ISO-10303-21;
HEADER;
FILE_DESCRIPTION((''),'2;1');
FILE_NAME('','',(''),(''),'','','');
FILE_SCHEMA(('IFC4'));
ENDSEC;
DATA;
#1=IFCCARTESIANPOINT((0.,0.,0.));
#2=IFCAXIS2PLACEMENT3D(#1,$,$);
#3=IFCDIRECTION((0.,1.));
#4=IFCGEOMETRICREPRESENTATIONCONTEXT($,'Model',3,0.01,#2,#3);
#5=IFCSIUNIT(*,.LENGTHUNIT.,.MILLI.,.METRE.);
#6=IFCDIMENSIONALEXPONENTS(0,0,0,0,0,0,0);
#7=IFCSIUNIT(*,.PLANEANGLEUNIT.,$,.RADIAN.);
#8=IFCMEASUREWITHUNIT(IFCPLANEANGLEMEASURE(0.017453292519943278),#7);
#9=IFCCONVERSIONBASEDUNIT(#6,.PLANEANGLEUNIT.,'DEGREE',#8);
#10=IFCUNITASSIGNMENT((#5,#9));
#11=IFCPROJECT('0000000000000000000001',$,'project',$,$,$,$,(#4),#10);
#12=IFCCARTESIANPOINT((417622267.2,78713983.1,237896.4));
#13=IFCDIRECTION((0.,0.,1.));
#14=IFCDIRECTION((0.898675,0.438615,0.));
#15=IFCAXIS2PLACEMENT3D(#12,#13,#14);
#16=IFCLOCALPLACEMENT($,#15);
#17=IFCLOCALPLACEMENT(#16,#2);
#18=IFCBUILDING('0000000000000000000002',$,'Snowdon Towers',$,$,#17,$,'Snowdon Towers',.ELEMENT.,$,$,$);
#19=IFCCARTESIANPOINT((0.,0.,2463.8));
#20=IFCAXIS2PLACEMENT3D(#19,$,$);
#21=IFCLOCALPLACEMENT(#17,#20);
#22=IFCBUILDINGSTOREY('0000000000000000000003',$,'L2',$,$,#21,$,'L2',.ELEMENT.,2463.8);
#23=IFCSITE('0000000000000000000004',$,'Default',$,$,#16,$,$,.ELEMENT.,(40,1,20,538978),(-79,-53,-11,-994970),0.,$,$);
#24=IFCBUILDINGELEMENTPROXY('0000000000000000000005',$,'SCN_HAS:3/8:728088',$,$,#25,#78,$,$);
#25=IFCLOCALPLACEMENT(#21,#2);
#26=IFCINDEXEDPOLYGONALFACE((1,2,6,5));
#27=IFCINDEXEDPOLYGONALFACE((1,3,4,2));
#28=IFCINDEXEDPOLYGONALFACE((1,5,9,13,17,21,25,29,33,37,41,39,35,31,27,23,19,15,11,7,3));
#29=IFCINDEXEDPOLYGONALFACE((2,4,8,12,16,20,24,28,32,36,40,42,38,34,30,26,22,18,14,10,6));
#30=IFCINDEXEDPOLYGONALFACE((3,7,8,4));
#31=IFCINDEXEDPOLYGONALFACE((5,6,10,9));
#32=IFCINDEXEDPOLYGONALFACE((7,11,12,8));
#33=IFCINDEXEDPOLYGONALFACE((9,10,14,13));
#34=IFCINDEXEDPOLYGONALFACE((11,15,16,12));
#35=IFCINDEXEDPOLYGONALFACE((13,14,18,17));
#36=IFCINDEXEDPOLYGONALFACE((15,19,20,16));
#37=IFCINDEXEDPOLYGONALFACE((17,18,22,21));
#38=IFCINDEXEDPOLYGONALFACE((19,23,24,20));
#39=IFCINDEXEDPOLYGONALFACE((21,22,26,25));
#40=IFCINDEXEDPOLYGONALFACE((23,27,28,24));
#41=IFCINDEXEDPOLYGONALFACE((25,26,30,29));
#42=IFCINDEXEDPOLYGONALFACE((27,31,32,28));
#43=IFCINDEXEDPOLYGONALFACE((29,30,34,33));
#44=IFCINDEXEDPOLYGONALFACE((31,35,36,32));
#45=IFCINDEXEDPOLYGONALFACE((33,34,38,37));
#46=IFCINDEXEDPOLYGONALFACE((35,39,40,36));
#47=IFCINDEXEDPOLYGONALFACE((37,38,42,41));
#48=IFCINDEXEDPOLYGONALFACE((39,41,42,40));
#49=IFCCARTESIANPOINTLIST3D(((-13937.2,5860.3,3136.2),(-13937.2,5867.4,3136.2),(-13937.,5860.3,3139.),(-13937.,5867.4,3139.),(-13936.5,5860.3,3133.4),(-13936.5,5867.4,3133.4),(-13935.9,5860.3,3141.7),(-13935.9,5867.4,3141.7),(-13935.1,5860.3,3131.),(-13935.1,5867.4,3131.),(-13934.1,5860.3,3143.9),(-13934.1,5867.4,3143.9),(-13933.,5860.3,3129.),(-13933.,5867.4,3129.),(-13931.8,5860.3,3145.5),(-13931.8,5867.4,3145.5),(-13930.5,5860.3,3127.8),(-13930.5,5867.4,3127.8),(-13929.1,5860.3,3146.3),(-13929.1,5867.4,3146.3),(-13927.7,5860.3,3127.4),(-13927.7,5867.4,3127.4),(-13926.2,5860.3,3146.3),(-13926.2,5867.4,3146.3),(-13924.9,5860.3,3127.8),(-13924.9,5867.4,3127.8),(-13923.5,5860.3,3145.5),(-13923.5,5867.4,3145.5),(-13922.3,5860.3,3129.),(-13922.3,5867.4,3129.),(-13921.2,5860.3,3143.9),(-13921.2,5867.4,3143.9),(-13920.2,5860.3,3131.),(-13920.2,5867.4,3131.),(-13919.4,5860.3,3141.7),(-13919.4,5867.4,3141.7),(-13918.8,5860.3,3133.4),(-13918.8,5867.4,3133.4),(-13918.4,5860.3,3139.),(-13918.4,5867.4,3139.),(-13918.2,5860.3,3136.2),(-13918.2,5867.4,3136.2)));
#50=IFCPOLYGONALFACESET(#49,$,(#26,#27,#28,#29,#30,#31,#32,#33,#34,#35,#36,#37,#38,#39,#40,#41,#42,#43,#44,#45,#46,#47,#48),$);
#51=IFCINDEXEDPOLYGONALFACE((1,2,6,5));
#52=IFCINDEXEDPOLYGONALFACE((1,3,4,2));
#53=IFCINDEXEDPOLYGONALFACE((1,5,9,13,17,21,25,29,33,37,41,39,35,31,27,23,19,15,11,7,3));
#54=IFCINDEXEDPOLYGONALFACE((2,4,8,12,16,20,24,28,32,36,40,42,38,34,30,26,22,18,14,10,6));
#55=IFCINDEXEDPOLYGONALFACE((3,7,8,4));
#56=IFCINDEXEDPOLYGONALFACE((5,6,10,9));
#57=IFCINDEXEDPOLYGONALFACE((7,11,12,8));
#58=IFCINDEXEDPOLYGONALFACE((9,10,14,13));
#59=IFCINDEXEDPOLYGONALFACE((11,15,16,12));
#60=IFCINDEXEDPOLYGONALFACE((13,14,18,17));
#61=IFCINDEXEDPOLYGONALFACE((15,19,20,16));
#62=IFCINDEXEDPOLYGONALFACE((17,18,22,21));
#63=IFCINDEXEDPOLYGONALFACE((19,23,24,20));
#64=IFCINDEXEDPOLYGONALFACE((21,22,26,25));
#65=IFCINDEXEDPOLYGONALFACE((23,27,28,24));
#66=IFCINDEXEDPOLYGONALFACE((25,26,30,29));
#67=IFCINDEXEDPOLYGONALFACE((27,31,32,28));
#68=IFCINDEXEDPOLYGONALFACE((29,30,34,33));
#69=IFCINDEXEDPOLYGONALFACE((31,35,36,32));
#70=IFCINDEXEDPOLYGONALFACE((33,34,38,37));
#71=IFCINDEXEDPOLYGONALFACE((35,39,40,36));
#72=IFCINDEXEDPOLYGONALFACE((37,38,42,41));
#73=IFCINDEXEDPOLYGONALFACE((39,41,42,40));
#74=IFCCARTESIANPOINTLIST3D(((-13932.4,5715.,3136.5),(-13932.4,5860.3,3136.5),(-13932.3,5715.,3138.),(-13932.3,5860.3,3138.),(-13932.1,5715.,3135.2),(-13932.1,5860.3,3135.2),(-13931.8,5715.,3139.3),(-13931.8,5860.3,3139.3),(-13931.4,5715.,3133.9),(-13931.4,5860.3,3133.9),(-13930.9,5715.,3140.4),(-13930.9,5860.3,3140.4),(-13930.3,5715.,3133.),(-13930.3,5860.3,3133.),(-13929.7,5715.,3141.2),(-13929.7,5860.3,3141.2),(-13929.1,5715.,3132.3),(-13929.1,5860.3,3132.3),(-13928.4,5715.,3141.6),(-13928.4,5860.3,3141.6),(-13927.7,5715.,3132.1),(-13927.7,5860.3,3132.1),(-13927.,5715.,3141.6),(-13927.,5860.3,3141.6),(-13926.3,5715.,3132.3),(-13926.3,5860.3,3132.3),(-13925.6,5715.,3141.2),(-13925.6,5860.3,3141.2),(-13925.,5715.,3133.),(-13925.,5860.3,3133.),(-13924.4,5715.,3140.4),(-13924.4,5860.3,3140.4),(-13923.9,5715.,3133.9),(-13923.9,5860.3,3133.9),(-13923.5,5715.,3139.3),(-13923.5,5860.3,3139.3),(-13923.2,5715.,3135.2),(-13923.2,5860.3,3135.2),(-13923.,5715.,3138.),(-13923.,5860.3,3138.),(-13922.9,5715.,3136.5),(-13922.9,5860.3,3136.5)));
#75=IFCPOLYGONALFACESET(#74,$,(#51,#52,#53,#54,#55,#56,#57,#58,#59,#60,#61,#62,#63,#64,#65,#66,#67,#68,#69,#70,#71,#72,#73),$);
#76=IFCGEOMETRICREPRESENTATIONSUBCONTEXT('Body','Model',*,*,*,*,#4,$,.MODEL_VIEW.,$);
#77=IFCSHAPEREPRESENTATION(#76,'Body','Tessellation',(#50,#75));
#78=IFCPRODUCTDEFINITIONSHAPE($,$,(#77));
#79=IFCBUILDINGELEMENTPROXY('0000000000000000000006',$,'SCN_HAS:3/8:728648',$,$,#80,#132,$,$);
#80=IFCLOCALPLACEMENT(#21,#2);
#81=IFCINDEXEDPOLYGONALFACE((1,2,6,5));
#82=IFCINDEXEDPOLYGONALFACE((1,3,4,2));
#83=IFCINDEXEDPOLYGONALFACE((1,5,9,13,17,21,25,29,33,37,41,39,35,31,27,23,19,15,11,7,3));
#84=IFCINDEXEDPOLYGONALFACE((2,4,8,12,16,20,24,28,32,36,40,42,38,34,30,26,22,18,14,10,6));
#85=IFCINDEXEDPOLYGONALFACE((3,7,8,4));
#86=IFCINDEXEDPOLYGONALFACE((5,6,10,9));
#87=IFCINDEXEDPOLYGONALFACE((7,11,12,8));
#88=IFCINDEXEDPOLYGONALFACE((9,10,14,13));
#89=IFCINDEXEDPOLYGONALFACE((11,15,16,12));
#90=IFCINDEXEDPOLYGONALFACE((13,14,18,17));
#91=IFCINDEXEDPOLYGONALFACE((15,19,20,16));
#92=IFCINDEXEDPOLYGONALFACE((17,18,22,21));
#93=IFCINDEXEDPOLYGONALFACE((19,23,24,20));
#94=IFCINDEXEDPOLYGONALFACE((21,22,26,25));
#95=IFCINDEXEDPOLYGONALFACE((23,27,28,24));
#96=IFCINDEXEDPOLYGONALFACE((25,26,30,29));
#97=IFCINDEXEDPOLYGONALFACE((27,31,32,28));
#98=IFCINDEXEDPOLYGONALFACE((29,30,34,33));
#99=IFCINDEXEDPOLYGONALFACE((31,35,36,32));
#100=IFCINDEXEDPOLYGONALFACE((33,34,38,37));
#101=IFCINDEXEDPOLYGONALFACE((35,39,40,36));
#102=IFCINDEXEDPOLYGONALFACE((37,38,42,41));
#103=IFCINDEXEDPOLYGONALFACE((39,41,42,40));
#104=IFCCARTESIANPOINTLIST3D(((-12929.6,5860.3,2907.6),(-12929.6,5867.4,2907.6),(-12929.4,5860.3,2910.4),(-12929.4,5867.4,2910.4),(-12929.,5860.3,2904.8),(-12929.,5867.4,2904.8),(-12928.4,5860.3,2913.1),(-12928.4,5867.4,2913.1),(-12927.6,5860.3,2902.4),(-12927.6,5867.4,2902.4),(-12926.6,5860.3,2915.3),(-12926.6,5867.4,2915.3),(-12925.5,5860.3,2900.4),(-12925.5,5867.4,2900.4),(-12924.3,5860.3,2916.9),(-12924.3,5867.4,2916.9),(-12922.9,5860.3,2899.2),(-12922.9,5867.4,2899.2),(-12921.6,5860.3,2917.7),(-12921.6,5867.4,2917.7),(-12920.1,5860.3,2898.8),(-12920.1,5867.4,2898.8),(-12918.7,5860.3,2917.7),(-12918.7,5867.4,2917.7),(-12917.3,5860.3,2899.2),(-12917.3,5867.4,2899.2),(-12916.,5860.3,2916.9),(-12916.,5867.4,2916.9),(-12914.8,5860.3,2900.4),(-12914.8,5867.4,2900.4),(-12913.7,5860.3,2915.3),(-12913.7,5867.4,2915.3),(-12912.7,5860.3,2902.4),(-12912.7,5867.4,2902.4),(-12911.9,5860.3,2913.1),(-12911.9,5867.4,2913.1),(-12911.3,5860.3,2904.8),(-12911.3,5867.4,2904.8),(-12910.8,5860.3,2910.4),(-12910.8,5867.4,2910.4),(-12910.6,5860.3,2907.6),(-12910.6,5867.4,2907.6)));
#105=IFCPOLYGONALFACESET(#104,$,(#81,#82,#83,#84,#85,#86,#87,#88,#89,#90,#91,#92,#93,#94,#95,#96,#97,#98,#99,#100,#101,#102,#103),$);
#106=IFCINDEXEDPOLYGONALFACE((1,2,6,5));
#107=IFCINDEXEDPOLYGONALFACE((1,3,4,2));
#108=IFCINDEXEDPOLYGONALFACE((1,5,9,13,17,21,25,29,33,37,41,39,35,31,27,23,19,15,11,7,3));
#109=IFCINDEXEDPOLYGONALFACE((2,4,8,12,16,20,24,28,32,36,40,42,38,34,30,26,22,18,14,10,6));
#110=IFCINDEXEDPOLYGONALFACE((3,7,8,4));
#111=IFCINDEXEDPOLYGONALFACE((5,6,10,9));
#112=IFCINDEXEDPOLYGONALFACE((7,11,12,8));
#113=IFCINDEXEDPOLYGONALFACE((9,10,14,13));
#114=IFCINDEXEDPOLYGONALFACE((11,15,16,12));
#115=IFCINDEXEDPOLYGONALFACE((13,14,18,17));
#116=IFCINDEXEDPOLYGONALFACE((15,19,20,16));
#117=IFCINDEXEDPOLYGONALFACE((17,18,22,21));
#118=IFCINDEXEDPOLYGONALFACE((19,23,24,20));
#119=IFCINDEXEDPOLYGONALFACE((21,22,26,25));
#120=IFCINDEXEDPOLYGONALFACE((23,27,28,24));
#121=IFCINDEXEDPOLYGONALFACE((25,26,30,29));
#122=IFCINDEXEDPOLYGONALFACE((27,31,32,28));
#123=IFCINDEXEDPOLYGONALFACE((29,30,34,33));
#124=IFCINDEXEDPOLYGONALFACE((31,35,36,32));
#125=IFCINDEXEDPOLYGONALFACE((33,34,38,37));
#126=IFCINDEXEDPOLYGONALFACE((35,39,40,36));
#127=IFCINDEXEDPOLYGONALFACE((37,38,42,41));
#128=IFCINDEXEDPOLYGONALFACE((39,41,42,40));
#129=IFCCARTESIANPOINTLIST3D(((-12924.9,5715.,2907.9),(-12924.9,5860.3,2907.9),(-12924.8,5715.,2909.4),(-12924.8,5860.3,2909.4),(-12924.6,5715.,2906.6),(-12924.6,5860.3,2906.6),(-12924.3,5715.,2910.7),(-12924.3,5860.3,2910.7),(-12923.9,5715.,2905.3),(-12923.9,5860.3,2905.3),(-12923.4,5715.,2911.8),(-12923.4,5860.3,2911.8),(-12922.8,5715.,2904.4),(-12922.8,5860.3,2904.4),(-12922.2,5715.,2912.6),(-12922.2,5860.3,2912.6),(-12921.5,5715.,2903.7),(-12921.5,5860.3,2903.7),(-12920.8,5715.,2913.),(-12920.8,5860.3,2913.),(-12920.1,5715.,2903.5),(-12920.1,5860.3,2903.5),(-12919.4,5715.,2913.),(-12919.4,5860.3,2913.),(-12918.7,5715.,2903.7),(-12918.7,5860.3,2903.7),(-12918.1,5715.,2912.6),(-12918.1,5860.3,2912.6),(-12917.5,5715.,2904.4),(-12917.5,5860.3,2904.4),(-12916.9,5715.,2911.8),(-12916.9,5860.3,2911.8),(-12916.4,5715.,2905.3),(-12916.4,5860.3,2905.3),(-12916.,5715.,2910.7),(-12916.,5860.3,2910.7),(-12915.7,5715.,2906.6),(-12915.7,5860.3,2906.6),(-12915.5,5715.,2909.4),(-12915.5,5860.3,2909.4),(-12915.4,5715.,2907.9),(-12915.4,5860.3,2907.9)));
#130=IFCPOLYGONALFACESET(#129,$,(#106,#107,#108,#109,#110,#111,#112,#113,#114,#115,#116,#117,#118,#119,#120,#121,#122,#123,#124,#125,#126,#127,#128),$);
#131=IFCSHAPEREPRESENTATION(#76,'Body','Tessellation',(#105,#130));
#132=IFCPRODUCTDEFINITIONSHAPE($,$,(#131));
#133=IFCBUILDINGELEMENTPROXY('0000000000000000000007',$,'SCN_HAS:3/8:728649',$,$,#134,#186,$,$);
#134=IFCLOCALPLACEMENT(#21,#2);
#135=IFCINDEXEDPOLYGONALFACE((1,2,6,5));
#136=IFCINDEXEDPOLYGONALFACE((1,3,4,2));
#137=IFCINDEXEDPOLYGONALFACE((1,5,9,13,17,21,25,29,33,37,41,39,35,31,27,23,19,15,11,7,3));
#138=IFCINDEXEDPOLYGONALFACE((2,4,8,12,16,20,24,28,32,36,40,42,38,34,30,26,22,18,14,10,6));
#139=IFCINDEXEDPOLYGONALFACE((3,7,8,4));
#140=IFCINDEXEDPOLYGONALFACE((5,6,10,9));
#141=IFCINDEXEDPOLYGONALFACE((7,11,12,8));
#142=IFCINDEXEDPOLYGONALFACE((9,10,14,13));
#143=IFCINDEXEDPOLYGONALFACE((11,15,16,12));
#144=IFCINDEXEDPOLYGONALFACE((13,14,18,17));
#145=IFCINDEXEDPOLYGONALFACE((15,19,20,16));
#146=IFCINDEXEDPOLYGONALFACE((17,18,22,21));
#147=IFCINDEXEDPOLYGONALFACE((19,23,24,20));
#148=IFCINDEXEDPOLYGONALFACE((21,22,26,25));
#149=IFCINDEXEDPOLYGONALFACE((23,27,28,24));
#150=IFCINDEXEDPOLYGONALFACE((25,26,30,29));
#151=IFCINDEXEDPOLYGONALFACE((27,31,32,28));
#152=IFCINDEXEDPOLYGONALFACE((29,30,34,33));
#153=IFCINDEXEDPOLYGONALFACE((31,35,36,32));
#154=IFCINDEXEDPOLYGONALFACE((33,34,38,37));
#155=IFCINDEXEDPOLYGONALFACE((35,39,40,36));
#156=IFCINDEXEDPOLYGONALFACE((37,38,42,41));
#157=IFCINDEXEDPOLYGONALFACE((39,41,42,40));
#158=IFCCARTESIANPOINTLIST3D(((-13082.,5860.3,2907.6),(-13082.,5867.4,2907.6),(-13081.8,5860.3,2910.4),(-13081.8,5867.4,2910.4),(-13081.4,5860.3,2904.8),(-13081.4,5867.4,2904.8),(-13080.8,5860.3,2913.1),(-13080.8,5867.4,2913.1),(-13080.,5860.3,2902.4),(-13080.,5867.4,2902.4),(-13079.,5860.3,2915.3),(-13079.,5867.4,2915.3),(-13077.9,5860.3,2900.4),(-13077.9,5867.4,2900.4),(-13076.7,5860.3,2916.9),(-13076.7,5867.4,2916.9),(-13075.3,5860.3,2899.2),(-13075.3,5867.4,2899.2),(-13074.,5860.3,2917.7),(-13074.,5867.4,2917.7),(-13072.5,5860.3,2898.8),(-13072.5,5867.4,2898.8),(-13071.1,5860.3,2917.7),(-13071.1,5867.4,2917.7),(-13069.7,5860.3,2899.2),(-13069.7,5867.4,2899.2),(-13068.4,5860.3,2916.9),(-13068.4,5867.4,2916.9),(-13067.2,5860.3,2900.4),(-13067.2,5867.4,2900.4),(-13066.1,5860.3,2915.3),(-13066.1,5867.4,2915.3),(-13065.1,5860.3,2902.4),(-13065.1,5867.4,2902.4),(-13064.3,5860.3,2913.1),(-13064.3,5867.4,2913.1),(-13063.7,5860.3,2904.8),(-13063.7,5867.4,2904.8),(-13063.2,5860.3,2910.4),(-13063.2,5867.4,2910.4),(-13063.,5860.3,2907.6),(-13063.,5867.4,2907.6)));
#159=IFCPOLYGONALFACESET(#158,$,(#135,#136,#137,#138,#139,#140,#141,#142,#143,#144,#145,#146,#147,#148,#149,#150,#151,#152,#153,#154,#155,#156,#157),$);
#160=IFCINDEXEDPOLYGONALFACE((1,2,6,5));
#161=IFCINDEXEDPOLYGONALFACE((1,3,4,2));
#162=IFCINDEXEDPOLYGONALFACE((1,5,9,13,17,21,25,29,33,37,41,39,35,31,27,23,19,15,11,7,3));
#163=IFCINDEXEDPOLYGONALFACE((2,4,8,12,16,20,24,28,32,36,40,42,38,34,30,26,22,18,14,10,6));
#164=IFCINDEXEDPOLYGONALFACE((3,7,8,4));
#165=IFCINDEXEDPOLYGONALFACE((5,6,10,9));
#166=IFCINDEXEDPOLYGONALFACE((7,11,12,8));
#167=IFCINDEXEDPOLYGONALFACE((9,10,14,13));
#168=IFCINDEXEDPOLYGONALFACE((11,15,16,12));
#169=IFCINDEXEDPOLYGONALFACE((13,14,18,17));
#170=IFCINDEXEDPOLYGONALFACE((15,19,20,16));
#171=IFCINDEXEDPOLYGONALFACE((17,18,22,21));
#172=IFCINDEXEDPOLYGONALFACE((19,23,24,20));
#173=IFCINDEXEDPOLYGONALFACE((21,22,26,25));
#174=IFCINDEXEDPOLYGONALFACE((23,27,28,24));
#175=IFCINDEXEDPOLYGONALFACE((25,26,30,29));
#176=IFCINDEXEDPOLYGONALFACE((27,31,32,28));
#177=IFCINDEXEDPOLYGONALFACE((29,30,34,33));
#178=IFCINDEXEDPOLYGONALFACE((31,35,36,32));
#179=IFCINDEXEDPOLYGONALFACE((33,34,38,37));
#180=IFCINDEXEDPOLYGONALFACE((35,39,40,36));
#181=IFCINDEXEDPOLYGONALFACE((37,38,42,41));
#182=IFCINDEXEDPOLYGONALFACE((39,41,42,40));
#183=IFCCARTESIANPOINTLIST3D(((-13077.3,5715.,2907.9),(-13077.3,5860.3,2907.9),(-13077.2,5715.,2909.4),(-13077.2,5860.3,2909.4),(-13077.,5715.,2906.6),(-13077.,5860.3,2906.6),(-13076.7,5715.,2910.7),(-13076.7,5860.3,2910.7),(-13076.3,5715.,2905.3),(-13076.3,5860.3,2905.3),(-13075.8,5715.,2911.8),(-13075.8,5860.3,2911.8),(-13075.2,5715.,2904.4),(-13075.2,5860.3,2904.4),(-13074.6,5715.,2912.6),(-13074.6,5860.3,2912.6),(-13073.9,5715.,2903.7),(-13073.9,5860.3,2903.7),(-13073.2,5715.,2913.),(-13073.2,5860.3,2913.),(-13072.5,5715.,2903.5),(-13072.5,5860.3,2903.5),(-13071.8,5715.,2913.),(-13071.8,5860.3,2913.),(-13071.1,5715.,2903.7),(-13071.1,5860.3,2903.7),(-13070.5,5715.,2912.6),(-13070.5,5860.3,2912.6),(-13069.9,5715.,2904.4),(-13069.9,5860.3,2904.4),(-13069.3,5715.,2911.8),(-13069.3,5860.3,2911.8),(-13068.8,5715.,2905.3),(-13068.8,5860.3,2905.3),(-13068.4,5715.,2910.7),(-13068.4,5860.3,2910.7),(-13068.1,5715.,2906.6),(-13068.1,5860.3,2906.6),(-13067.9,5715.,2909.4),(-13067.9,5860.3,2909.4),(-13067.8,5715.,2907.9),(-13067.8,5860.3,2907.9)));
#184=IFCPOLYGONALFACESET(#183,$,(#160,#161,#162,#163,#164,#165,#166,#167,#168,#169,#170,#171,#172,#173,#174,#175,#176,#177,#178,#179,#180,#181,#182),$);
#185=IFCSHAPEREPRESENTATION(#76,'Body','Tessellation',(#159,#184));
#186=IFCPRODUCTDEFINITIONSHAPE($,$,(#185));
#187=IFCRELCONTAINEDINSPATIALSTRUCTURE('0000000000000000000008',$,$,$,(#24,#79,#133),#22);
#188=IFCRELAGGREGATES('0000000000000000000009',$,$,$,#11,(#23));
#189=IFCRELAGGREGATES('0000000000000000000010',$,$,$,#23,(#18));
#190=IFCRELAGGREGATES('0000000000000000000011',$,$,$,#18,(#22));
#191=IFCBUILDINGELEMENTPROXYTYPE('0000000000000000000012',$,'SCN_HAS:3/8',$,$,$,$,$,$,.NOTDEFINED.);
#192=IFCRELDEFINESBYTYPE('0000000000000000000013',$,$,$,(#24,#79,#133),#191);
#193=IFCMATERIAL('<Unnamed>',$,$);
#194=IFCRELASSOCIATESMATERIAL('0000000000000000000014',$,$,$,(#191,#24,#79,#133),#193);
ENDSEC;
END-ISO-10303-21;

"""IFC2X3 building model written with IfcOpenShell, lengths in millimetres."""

from ifc_helpers import new_model, entity, si_unit, converted_unit, direction, frame, frame_2d, origin, place, context, subcontext, project, spatial, circle, extrude, source, transform, mapped, material, type_object, type_shapes, element, save


model = new_model("IFC2X3")

# Units and contexts
model_context = context("Model", 3, precision=0.01, world=origin(), true_north=direction((0.0, 1.0)))
body_context = subcontext(model_context, "Body", "Model", "MODEL_VIEW")
ifc_project = project(units=[si_unit("LENGTHUNIT", "METRE", prefix="MILLI"), converted_unit("PLANEANGLEUNIT", "DEGREE", entity("IfcPlaneAngleMeasure", 0.017453292519943278), si_unit("PLANEANGLEUNIT", "RADIAN"), dimensions=[0, 0, 0, 0, 0, 0, 0])], contexts=[model_context])

# Site, building, storey
site_placement = place(None, frame((417622267.2, 78713983.1, 237896.4), z_axis=(0.0, 0.0, 1.0), x_axis=(0.898675, 0.438615, 0.0)))
site = spatial("IfcSite", under=ifc_project, at=site_placement, Name="Default", CompositionType="ELEMENT", RefLatitude=(40, 1, 20, 538978), RefLongitude=(-79, -53, -11, -994970), RefElevation=0.0)
building_placement = place(site_placement, origin())
building = spatial("IfcBuilding", under=site, at=building_placement, Name="Snowdon Towers", LongName="Snowdon Towers", CompositionType="ELEMENT")
storey_placement = place(building_placement, frame((0.0, 0.0, 2463.8)))
storey = spatial("IfcBuildingStorey", under=building, at=storey_placement, Name="L2", LongName="L2", CompositionType="ELEMENT", Elevation=2463.8)

# Building element proxies
ifc_material_1 = material(Name="<Unnamed>")
building_element_proxy_type_1 = type_object("IfcBuildingElementProxyType", Name="SCN_HAS:3/8", PredefinedType="NOTDEFINED", material=ifc_material_1)
shared_shape_1 = source(origin(), body_context, "Body", "SweptSolid", [
    extrude(circle(Radius=9.5, at=frame_2d((0.0, 0.0), x_axis=(1.0, 0.0))), frame((0.0, 0.0, -152.4), z_axis=(0.0, 0.0, 1.0), x_axis=(0.0, -1.0, 0.0)), (0.0, 0.0, 1.0), 7.1),
    extrude(circle(Radius=4.8, at=frame_2d((0.0, 0.0), x_axis=(1.0, 0.0))), frame((0.0, 0.0, -145.3), z_axis=(0.0, 0.0, 1.0), x_axis=(0.0, -1.0, 0.0)), (0.0, 0.0, 1.0), 145.3),
])
type_shapes(building_element_proxy_type_1, [shared_shape_1])
for number, where, z_axis, x_axis, name in (
    (1, (-13927.7, 5715.0, 3136.9), (0.0, -1.0, 0.0), (1.0, 0.0, 0.0), "SCN_HAS:3/8:728088"),
    (2, (-12920.1, 5715.0, 2908.3), (0.0, -1.0, 0.0), (1.0, 0.0, 0.0), "SCN_HAS:3/8:728648"),
    (3, (-13072.5, 5715.0, 2908.3), (0.0, -1.0, 0.0), (1.0, 0.0, 0.0), "SCN_HAS:3/8:728649"),
):
    element("IfcBuildingElementProxy", number, at=place(storey_placement, frame(where, z_axis=z_axis, x_axis=x_axis)), inside=storey, type_object=building_element_proxy_type_1, material=ifc_material_1, Name=name, context=body_context, shape_type="MappedRepresentation", body=[
        mapped(shared_shape_1, transform((0.0, 0.0, 0.0), scale=1.0)),
    ])

save(model, "model.ifc")
